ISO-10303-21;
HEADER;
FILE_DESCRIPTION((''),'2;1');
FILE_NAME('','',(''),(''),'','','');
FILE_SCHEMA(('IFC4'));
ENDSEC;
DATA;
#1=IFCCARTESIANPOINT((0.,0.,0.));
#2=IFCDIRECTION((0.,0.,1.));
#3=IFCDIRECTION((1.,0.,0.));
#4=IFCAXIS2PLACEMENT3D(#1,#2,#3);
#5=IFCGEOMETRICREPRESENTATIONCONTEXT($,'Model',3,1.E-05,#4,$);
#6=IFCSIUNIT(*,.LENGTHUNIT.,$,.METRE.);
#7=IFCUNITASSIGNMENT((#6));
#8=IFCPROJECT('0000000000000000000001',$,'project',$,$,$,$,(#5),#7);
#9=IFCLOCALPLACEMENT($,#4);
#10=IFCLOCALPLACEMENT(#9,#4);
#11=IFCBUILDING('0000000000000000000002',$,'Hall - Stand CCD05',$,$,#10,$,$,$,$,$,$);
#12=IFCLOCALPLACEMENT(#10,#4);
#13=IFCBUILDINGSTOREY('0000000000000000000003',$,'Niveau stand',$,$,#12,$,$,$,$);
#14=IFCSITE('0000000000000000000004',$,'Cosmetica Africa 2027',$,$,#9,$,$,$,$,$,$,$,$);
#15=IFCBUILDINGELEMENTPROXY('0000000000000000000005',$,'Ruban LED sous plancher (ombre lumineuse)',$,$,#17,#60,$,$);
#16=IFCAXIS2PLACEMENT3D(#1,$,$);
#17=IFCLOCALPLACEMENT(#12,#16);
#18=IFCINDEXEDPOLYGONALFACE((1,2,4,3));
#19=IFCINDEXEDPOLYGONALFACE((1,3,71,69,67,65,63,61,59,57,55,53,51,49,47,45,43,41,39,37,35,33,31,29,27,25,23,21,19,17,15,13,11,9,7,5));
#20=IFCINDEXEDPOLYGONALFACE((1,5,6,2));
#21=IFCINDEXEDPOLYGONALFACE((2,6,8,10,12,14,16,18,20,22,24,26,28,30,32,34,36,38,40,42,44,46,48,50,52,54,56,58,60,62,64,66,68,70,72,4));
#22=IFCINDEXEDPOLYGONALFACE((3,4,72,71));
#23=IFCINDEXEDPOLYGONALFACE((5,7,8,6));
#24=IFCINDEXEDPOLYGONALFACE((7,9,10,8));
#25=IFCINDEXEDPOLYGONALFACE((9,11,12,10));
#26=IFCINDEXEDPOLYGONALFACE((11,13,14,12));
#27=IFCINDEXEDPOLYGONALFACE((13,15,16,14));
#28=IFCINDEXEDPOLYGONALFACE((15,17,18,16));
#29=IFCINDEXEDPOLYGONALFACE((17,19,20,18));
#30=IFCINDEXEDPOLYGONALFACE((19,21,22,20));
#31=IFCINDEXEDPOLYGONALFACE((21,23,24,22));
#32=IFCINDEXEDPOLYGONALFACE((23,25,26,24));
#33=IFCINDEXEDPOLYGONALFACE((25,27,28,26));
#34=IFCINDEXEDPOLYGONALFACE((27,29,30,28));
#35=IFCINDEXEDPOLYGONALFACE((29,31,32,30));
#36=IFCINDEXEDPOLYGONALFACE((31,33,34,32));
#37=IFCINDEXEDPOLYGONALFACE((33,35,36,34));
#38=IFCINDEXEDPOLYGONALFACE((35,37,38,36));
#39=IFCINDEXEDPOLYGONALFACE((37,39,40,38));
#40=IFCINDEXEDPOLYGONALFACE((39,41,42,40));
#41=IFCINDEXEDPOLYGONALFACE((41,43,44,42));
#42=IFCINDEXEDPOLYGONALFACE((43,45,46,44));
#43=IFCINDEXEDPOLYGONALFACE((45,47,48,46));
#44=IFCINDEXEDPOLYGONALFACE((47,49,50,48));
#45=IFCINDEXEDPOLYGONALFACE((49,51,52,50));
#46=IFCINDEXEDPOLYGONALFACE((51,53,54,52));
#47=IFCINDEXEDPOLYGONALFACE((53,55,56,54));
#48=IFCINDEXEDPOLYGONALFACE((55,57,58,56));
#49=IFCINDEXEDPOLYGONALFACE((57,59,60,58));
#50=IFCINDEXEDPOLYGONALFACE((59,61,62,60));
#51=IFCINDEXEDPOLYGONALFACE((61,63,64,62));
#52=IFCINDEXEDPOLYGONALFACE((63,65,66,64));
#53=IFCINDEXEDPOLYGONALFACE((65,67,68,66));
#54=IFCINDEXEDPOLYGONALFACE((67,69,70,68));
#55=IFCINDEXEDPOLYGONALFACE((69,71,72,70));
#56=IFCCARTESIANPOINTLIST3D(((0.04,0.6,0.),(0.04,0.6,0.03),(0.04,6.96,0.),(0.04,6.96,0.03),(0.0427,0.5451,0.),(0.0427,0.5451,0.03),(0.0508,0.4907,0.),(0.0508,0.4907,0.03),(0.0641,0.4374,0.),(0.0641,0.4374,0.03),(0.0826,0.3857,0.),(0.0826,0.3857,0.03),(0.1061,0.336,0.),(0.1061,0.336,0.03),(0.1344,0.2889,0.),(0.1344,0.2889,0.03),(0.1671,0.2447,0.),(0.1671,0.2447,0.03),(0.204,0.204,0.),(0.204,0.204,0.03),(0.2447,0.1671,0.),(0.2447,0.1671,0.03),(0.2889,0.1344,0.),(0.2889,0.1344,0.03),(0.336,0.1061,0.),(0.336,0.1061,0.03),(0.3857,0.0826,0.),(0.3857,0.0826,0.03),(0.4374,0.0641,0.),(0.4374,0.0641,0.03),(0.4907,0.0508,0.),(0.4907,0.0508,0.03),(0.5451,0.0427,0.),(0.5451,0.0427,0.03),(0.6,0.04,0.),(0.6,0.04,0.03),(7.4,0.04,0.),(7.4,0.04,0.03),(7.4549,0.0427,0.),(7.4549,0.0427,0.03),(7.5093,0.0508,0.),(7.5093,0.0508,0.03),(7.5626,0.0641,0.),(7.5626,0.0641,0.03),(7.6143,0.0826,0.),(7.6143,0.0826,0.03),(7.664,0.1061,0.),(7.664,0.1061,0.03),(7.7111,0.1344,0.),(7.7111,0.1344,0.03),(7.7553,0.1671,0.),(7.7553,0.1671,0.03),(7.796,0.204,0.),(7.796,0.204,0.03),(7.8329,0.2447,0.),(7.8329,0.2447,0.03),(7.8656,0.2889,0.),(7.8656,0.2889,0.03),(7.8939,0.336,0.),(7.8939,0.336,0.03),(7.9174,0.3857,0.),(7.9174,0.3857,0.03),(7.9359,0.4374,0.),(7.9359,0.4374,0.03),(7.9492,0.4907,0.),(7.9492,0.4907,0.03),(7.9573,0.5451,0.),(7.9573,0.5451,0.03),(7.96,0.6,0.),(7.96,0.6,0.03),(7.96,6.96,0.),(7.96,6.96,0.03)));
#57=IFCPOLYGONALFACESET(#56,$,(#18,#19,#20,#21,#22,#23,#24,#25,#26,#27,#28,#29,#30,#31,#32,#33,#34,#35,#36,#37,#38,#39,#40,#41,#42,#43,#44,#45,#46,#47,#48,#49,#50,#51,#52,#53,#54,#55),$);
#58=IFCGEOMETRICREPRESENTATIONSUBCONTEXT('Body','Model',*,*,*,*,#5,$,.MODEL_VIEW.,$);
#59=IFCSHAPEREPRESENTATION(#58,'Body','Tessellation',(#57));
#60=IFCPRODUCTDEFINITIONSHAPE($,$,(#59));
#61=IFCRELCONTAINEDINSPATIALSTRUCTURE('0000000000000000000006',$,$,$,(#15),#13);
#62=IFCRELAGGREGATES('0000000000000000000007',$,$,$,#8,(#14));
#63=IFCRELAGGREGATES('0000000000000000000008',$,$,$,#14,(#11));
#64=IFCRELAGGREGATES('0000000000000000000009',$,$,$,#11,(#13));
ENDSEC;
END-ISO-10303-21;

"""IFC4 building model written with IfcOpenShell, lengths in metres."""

from ifc_helpers import new_model, si_unit, origin, origin_with_axes, place, context, subcontext, project, spatial, polyline, outline, extrude, element, save


model = new_model("IFC4")

# Units and contexts
model_context = context("Model", 3, precision=1e-05, world=origin_with_axes())
body_context = subcontext(model_context, "Body", "Model", "MODEL_VIEW")
ifc_project = project(units=[si_unit("LENGTHUNIT", "METRE")], contexts=[model_context])

# Site, building, storey
site_placement = place(None, origin_with_axes())
site = spatial("IfcSite", under=ifc_project, at=site_placement, Name="Cosmetica Africa 2027")
building_placement = place(site_placement, origin_with_axes())
building = spatial("IfcBuilding", under=site, at=building_placement, Name="Hall - Stand CCD05")
storey_placement = place(building_placement, origin_with_axes())
storey = spatial("IfcBuildingStorey", under=building, at=storey_placement, Name="Niveau stand")

# Building element proxy
proxy_placement = place(storey_placement, origin_with_axes())
element("IfcBuildingElementProxy", 1, at=proxy_placement, inside=storey, Name="Ruban LED sous plancher (ombre lumineuse)", context=body_context, shape_type="SweptSolid", body=[
    extrude(outline(polyline([(0.04, 0.6), (0.0427, 0.5451), (0.0508, 0.4907), (0.0641, 0.4374), (0.0826, 0.3857), (0.1061, 0.336), (0.1344, 0.2889), (0.1671, 0.2447), (0.204, 0.204), (0.2447, 0.1671), (0.2889, 0.1344), (0.336, 0.1061), (0.3857, 0.0826), (0.4374, 0.0641), (0.4907, 0.0508), (0.5451, 0.0427), (0.6, 0.04), (7.4, 0.04), (7.4549, 0.0427), (7.5093, 0.0508), (7.5626, 0.0641), (7.6143, 0.0826), (7.664, 0.1061), (7.7111, 0.1344), (7.7553, 0.1671), (7.796, 0.204), (7.8329, 0.2447), (7.8656, 0.2889), (7.8939, 0.336), (7.9174, 0.3857), (7.9359, 0.4374), (7.9492, 0.4907), (7.9573, 0.5451), (7.96, 0.6), (7.96, 6.96), (0.04, 6.96), (0.04, 0.6)])), origin(), (0.0, 0.0, 1.0), 0.03),
])

save(model, "model.ifc")
